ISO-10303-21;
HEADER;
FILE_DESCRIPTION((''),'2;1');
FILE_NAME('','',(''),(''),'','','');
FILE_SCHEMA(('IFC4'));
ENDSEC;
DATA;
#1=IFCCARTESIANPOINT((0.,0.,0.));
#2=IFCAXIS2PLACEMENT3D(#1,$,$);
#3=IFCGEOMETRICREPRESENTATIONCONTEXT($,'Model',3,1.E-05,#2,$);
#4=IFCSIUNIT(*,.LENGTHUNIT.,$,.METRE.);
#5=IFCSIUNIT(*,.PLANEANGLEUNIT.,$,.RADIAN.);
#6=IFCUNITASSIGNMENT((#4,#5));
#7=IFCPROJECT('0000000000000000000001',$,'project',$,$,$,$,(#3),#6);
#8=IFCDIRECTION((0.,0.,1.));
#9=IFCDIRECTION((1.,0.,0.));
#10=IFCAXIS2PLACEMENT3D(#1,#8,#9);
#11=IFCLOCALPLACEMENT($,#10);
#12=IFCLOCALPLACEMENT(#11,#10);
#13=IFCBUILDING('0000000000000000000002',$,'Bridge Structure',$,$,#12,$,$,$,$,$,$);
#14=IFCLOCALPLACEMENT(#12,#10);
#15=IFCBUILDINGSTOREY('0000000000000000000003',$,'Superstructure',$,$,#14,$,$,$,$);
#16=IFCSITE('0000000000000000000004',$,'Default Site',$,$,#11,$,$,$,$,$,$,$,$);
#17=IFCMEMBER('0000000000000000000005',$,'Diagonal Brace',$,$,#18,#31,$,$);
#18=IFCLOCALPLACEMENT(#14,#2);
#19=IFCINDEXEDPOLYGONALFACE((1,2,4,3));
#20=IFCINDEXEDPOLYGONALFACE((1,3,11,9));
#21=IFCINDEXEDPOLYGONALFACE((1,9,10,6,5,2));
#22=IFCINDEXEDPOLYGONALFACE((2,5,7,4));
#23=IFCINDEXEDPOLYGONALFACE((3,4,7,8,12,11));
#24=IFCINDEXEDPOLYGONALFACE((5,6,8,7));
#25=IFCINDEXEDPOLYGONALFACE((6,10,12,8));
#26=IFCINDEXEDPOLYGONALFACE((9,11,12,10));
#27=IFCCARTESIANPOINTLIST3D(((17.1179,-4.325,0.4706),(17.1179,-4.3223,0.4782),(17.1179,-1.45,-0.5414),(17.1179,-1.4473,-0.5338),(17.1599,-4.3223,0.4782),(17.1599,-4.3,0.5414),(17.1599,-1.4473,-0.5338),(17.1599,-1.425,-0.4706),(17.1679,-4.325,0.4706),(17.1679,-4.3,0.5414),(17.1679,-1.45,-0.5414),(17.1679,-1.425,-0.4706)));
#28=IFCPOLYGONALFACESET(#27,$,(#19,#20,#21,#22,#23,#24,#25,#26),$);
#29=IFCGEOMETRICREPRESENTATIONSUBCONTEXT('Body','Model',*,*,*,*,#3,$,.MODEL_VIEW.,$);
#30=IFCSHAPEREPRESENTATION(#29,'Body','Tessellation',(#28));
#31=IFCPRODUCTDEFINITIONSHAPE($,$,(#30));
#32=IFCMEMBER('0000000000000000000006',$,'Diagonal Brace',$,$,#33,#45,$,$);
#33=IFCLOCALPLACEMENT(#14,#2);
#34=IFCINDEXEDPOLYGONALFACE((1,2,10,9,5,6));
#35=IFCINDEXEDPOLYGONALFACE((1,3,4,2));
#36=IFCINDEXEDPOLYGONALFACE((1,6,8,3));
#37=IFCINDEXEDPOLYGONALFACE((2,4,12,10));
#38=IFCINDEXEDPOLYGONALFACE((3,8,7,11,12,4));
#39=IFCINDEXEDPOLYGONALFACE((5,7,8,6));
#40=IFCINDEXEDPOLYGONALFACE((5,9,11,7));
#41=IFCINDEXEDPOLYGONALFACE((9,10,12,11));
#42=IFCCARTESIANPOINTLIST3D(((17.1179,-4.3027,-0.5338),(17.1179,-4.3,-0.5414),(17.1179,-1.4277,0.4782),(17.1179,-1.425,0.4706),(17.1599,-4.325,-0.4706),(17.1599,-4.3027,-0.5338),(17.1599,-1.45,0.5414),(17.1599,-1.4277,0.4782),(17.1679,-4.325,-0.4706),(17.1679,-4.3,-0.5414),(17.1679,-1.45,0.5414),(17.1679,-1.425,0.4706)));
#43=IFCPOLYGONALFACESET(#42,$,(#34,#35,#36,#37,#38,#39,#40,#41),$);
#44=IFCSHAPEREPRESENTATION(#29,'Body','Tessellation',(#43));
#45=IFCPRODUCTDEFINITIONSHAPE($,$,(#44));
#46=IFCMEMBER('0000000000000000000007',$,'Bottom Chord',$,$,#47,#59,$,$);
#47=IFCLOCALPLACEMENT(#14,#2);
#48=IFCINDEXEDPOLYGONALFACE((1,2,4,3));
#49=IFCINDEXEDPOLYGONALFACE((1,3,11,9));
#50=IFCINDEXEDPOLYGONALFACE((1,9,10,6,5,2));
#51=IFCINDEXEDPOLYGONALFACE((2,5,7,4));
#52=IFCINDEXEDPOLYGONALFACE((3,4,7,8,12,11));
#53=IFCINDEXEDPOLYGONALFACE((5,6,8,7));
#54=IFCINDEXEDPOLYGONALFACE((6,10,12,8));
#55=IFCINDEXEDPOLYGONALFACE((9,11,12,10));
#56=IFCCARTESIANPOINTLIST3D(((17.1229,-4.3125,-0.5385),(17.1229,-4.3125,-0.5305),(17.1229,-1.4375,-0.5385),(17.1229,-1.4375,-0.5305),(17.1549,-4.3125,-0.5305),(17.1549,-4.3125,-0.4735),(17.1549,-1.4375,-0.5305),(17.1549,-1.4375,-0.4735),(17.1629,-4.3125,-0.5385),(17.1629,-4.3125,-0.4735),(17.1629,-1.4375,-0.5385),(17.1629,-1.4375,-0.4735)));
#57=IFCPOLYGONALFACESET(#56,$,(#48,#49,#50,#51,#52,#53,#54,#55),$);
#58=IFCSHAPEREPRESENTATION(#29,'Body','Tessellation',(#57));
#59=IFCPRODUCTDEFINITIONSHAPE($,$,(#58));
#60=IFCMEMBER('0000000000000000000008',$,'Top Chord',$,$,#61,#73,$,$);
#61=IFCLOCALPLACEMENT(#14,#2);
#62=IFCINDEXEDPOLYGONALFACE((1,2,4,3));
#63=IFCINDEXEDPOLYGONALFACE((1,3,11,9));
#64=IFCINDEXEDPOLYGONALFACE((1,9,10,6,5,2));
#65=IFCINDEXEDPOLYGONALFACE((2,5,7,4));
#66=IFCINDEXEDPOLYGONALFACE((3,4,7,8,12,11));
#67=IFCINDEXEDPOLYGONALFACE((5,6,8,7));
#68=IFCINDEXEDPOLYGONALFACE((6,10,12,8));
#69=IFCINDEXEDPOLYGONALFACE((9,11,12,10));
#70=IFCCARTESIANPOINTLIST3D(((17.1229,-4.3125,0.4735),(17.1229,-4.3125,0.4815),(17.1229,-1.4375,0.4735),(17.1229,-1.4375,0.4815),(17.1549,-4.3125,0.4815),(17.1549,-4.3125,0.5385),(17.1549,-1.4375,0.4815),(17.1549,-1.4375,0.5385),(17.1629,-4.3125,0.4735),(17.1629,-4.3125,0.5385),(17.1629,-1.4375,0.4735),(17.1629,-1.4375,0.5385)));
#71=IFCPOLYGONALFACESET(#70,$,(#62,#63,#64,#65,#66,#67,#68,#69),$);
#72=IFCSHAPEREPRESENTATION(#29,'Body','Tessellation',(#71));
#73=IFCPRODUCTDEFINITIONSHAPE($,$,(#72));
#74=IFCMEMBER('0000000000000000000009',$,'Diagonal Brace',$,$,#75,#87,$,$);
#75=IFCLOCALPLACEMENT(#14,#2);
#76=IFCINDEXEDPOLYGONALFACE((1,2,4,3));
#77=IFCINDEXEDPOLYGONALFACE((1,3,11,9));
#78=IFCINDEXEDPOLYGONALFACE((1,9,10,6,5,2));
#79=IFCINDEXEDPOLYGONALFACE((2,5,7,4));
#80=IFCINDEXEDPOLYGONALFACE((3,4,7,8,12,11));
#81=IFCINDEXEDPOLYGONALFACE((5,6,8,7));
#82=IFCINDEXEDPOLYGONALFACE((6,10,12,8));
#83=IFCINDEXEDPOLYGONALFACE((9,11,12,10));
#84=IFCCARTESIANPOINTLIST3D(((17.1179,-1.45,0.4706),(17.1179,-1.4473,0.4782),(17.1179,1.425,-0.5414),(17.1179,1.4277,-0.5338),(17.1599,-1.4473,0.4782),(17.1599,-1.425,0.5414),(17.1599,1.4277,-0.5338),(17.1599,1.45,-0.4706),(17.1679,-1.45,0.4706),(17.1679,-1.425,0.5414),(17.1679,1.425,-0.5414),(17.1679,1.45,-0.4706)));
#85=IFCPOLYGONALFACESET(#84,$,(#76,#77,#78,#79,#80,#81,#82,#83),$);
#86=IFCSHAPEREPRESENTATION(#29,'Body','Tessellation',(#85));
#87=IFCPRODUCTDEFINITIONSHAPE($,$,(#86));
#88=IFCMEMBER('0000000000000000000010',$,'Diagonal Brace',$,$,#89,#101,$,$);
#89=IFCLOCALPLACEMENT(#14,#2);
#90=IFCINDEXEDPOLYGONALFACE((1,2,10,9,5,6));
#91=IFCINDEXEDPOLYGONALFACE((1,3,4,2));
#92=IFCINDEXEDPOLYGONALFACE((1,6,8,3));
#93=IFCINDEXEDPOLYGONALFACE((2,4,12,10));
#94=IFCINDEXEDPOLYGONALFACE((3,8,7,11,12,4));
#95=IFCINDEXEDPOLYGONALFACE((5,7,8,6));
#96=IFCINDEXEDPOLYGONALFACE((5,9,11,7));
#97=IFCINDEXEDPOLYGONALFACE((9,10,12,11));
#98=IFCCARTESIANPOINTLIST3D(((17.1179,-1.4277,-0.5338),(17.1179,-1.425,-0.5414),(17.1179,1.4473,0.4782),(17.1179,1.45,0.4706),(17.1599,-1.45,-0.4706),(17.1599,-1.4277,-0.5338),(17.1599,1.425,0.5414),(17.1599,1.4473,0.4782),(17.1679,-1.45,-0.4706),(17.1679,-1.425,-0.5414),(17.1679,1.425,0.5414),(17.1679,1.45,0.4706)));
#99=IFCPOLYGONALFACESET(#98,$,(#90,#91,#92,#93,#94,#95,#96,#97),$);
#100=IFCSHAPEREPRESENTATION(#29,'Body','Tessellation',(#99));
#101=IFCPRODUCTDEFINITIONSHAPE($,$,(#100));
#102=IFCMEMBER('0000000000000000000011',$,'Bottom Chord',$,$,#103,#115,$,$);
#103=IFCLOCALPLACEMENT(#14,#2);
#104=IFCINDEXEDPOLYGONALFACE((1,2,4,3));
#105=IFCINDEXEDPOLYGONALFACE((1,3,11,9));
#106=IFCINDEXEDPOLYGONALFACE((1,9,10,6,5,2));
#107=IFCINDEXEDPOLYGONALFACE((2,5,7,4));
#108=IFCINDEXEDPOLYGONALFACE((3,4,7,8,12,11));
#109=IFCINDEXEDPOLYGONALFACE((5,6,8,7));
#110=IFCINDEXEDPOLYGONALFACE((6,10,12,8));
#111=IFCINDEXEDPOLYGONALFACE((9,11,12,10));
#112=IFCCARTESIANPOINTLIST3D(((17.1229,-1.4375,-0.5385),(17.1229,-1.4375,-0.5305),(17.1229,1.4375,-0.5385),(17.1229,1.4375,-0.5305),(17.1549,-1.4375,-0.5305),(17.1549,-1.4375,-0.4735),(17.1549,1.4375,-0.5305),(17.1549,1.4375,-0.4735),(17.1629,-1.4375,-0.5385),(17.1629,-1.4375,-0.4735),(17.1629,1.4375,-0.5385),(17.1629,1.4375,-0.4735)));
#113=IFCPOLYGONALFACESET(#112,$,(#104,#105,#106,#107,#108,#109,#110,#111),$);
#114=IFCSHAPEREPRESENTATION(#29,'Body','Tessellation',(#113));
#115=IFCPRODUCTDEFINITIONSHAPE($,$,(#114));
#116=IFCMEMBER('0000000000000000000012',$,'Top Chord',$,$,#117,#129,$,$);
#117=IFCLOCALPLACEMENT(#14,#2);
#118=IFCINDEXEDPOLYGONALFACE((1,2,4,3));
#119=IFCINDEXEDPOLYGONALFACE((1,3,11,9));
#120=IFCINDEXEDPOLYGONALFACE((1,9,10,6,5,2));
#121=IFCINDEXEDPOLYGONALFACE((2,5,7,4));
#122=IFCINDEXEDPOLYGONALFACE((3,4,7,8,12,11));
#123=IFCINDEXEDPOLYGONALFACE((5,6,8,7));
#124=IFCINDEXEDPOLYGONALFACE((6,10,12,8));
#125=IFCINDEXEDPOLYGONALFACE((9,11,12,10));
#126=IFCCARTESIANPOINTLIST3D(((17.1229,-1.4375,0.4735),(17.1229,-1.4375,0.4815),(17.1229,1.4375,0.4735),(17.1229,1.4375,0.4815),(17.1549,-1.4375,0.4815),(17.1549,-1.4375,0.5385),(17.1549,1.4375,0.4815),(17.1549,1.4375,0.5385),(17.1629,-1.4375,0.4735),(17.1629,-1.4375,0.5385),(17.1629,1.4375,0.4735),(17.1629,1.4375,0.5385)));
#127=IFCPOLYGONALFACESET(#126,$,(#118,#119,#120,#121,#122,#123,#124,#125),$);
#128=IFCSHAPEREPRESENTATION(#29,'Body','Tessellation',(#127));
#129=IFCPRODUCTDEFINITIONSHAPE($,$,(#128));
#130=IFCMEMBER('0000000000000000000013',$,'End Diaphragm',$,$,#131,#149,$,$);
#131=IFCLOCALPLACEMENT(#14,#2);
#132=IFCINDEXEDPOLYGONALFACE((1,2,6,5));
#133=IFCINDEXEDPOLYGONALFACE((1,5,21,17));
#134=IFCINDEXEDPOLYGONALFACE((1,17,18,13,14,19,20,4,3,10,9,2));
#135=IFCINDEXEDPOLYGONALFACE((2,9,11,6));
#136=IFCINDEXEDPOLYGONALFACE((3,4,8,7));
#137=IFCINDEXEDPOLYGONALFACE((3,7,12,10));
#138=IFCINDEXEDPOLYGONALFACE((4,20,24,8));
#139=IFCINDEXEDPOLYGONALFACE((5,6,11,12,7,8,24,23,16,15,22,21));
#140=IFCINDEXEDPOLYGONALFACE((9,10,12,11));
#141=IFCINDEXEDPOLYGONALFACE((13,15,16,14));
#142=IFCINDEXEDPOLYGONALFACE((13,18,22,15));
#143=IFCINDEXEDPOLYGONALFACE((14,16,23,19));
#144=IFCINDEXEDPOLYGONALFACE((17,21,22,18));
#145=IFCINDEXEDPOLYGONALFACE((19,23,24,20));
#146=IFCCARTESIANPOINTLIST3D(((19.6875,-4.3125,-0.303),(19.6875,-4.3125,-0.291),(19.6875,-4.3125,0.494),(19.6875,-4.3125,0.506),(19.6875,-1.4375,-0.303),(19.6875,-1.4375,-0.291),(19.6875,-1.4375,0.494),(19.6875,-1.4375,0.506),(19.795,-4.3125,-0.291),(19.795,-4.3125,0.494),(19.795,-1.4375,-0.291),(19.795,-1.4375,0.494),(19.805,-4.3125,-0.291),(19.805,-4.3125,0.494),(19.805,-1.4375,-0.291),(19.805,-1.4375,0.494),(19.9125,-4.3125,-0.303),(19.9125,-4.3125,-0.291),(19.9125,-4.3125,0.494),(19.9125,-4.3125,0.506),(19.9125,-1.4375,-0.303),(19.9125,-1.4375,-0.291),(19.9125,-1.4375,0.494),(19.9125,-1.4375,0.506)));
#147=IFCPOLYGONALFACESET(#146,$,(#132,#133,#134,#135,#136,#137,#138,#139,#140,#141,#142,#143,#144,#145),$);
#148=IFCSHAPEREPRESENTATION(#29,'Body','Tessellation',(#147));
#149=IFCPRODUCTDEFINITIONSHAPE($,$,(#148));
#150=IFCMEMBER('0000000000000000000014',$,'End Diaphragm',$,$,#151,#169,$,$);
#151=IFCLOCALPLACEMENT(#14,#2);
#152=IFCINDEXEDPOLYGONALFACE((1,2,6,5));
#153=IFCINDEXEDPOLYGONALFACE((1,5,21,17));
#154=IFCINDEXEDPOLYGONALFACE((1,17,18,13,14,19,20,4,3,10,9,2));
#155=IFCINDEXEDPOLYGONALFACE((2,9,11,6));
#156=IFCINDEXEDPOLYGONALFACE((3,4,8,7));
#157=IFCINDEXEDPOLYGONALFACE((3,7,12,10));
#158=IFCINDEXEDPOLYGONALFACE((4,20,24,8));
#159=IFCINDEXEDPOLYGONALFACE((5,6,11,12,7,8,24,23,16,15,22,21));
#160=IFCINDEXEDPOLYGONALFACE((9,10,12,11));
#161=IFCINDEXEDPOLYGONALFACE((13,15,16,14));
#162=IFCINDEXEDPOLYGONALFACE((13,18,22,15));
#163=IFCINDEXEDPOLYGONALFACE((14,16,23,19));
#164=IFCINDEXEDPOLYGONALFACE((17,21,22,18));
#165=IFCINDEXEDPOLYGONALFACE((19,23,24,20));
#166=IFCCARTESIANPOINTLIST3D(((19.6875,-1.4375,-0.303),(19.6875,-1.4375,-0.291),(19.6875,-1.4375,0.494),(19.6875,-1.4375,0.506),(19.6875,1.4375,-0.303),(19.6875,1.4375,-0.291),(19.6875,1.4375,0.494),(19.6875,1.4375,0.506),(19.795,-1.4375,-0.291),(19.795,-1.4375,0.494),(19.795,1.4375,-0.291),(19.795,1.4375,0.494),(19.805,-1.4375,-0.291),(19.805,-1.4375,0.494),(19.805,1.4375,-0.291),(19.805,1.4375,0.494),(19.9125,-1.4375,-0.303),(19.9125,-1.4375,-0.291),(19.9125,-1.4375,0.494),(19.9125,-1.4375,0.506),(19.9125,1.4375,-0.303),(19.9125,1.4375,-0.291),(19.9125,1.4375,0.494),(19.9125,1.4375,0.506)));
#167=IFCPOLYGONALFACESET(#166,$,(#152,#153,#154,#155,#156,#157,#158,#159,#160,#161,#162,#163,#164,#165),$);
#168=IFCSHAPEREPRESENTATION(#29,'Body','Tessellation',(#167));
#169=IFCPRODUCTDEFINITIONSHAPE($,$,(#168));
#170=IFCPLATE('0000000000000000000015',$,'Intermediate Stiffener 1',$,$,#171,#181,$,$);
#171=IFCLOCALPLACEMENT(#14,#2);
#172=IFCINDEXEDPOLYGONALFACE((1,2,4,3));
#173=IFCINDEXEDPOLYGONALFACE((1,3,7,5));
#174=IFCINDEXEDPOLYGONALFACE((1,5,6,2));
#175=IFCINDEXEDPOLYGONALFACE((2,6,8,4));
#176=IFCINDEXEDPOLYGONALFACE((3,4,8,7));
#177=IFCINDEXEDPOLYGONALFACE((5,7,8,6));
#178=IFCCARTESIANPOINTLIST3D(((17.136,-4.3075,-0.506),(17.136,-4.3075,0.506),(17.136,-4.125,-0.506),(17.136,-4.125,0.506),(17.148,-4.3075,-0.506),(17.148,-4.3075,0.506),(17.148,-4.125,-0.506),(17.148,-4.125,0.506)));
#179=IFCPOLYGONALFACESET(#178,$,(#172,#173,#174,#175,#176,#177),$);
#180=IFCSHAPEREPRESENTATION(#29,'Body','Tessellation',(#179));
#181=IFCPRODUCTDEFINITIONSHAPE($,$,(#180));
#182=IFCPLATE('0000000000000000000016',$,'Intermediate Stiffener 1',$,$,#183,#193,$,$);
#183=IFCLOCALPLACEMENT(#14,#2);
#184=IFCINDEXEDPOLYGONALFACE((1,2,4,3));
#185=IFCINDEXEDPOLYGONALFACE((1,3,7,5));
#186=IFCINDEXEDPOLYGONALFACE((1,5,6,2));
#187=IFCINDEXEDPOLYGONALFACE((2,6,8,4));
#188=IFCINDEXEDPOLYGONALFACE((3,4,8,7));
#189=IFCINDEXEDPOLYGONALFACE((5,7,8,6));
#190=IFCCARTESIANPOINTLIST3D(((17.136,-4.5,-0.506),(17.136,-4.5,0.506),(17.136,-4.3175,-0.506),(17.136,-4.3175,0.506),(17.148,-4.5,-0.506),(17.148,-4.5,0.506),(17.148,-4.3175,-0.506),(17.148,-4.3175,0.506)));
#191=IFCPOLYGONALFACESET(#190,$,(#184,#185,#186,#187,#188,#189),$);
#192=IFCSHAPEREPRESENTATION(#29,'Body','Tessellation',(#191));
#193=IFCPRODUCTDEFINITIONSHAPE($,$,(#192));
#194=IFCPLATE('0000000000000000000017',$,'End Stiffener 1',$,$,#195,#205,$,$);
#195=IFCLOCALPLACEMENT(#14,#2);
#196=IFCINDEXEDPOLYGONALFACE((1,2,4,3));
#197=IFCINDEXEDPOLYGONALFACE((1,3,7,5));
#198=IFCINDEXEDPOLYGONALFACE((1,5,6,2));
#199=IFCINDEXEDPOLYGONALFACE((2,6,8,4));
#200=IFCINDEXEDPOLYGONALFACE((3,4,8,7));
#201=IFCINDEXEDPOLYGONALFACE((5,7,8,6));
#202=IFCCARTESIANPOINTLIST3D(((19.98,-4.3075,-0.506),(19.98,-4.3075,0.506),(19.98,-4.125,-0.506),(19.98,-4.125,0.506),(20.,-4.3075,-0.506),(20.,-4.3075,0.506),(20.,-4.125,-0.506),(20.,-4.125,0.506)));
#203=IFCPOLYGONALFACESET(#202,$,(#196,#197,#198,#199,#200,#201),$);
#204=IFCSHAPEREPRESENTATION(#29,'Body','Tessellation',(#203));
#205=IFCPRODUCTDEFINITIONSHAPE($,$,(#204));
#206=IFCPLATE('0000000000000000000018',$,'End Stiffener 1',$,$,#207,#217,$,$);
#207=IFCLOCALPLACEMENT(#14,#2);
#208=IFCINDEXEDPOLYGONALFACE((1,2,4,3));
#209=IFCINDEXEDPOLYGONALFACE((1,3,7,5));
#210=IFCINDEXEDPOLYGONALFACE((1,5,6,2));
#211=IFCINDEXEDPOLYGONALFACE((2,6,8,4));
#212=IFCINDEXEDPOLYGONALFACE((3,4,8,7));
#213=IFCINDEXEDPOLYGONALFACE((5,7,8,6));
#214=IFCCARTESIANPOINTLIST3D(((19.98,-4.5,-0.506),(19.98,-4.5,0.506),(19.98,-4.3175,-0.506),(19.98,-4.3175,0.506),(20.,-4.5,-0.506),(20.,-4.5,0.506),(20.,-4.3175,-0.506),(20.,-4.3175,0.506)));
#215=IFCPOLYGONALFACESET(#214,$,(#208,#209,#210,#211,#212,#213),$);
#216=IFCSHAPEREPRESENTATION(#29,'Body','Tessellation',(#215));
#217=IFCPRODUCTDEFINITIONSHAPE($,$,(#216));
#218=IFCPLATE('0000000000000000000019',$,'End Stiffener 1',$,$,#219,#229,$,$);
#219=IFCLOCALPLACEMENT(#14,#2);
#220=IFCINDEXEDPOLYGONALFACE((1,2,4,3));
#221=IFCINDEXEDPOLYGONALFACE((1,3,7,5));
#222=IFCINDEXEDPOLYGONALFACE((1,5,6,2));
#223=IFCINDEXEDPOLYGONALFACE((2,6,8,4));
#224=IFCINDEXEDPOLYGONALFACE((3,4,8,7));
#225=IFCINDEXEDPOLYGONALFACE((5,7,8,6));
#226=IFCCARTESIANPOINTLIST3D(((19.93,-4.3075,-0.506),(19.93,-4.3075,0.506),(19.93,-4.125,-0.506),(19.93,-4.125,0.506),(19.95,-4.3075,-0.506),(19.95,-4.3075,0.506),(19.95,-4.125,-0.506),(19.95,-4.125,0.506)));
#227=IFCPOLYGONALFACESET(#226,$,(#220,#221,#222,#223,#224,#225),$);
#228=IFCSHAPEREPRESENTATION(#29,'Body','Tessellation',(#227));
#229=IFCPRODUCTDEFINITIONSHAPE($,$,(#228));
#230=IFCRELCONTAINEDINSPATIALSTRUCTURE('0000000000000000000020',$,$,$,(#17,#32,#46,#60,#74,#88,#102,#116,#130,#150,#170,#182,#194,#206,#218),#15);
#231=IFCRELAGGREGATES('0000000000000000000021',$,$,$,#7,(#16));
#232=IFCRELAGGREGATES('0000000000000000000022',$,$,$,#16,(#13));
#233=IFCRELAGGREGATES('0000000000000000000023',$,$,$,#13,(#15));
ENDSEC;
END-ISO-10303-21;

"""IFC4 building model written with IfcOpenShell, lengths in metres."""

from ifc_helpers import new_model, si_unit, frame, origin, origin_with_axes, origin_2d_with_axis, place, context, subcontext, project, spatial, rectangle, i_section, l_section, extrude, element, save


model = new_model("IFC4")

# Units and contexts
model_context = context("Model", 3, precision=1e-05, world=origin())
body_context = subcontext(model_context, "Body", "Model", "MODEL_VIEW")
ifc_project = project(units=[si_unit("LENGTHUNIT", "METRE"), si_unit("PLANEANGLEUNIT", "RADIAN")], contexts=[model_context])

# Site, building, storey
site_placement = place(None, origin_with_axes())
site = spatial("IfcSite", under=ifc_project, at=site_placement, Name="Default Site")
building_placement = place(site_placement, origin_with_axes())
building = spatial("IfcBuilding", under=site, at=building_placement, Name="Bridge Structure")
storey_placement = place(building_placement, origin_with_axes())
storey = spatial("IfcBuildingStorey", under=building, at=storey_placement, Name="Superstructure")

# Members
for number, where, z_axis, x_axis, name in (
    (1, (17.1429, -4.3125, 0.506), (0.0, 0.943269, -0.332031), (-1.0, 0.0, 0.0), "Diagonal Brace"),
    (2, (17.1429, -4.3125, -0.506), (0.0, 0.943269, 0.332031), (-1.0, 0.0, 0.0), "Diagonal Brace"),
):
    element("IfcMember", number, at=place(storey_placement, frame(where, z_axis=z_axis, x_axis=x_axis)), inside=storey, Name=name, context=body_context, shape_type="SweptSolid", body=[
        extrude(l_section(Depth=0.075, Width=0.05, Thickness=0.008, at=origin_2d_with_axis()), origin_with_axes(), (0.0, 0.0, 1.0), 3.0479),
    ])
for number, where, z_axis, x_axis, name in (
    (3, (17.1429, -4.3125, -0.506), (0.0, 1.0, 0.0), (-1.0, 0.0, 0.0), "Bottom Chord"),
    (4, (17.1429, -4.3125, 0.506), (0.0, 1.0, 0.0), (-1.0, 0.0, 0.0), "Top Chord"),
):
    element("IfcMember", number, at=place(storey_placement, frame(where, z_axis=z_axis, x_axis=x_axis)), inside=storey, Name=name, context=body_context, shape_type="SweptSolid", body=[
        extrude(l_section(Depth=0.065, Width=0.04, Thickness=0.008, at=origin_2d_with_axis()), origin_with_axes(), (0.0, 0.0, 1.0), 2.875),
    ])
for number, where, z_axis, x_axis, name in (
    (5, (17.1429, -1.4375, 0.506), (0.0, 0.943269, -0.332031), (-1.0, 0.0, 0.0), "Diagonal Brace"),
    (6, (17.1429, -1.4375, -0.506), (0.0, 0.943269, 0.332031), (-1.0, 0.0, 0.0), "Diagonal Brace"),
):
    element("IfcMember", number, at=place(storey_placement, frame(where, z_axis=z_axis, x_axis=x_axis)), inside=storey, Name=name, context=body_context, shape_type="SweptSolid", body=[
        extrude(l_section(Depth=0.075, Width=0.05, Thickness=0.008, at=origin_2d_with_axis()), origin_with_axes(), (0.0, 0.0, 1.0), 3.0479),
    ])
for number, where, z_axis, x_axis, name in (
    (7, (17.1429, -1.4375, -0.506), (0.0, 1.0, 0.0), (-1.0, 0.0, 0.0), "Bottom Chord"),
    (8, (17.1429, -1.4375, 0.506), (0.0, 1.0, 0.0), (-1.0, 0.0, 0.0), "Top Chord"),
):
    element("IfcMember", number, at=place(storey_placement, frame(where, z_axis=z_axis, x_axis=x_axis)), inside=storey, Name=name, context=body_context, shape_type="SweptSolid", body=[
        extrude(l_section(Depth=0.065, Width=0.04, Thickness=0.008, at=origin_2d_with_axis()), origin_with_axes(), (0.0, 0.0, 1.0), 2.875),
    ])
for number, where, z_axis, x_axis, name in (
    (9, (19.8, -4.3125, 0.1015), (0.0, 1.0, 0.0), (-1.0, 0.0, 0.0), "End Diaphragm"),
    (10, (19.8, -1.4375, 0.1015), (0.0, 1.0, 0.0), (-1.0, 0.0, 0.0), "End Diaphragm"),
):
    element("IfcMember", number, at=place(storey_placement, frame(where, z_axis=z_axis, x_axis=x_axis)), inside=storey, Name=name, context=body_context, shape_type="SweptSolid", body=[
        extrude(i_section(OverallWidth=0.225, OverallDepth=0.809, WebThickness=0.01, FlangeThickness=0.012, at=origin_2d_with_axis()), origin_with_axes(), (0.0, 0.0, 1.0), 2.875),
    ])

# Plates
for number, where, z_axis, x_axis, name in (
    (11, (17.142, -4.2163, -0.506), (0.0, 0.0, 1.0), (1.0, 0.0, 0.0), "Intermediate Stiffener 1"),
    (12, (17.142, -4.4088, -0.506), (0.0, 0.0, 1.0), (1.0, 0.0, 0.0), "Intermediate Stiffener 1"),
):
    element("IfcPlate", number, at=place(storey_placement, frame(where, z_axis=z_axis, x_axis=x_axis)), inside=storey, Name=name, context=body_context, shape_type="SweptSolid", body=[
        extrude(rectangle(XDim=0.012, YDim=0.1825, at=origin_2d_with_axis()), origin_with_axes(), (0.0, 0.0, 1.0), 1.012),
    ])
for number, where, z_axis, x_axis, name in (
    (13, (19.99, -4.2163, -0.506), (0.0, 0.0, 1.0), (1.0, 0.0, 0.0), "End Stiffener 1"),
    (14, (19.99, -4.4088, -0.506), (0.0, 0.0, 1.0), (1.0, 0.0, 0.0), "End Stiffener 1"),
    (15, (19.94, -4.2163, -0.506), (0.0, 0.0, 1.0), (1.0, 0.0, 0.0), "End Stiffener 1"),
):
    element("IfcPlate", number, at=place(storey_placement, frame(where, z_axis=z_axis, x_axis=x_axis)), inside=storey, Name=name, context=body_context, shape_type="SweptSolid", body=[
        extrude(rectangle(XDim=0.02, YDim=0.1825, at=origin_2d_with_axis()), origin_with_axes(), (0.0, 0.0, 1.0), 1.012),
    ])

save(model, "model.ifc")
